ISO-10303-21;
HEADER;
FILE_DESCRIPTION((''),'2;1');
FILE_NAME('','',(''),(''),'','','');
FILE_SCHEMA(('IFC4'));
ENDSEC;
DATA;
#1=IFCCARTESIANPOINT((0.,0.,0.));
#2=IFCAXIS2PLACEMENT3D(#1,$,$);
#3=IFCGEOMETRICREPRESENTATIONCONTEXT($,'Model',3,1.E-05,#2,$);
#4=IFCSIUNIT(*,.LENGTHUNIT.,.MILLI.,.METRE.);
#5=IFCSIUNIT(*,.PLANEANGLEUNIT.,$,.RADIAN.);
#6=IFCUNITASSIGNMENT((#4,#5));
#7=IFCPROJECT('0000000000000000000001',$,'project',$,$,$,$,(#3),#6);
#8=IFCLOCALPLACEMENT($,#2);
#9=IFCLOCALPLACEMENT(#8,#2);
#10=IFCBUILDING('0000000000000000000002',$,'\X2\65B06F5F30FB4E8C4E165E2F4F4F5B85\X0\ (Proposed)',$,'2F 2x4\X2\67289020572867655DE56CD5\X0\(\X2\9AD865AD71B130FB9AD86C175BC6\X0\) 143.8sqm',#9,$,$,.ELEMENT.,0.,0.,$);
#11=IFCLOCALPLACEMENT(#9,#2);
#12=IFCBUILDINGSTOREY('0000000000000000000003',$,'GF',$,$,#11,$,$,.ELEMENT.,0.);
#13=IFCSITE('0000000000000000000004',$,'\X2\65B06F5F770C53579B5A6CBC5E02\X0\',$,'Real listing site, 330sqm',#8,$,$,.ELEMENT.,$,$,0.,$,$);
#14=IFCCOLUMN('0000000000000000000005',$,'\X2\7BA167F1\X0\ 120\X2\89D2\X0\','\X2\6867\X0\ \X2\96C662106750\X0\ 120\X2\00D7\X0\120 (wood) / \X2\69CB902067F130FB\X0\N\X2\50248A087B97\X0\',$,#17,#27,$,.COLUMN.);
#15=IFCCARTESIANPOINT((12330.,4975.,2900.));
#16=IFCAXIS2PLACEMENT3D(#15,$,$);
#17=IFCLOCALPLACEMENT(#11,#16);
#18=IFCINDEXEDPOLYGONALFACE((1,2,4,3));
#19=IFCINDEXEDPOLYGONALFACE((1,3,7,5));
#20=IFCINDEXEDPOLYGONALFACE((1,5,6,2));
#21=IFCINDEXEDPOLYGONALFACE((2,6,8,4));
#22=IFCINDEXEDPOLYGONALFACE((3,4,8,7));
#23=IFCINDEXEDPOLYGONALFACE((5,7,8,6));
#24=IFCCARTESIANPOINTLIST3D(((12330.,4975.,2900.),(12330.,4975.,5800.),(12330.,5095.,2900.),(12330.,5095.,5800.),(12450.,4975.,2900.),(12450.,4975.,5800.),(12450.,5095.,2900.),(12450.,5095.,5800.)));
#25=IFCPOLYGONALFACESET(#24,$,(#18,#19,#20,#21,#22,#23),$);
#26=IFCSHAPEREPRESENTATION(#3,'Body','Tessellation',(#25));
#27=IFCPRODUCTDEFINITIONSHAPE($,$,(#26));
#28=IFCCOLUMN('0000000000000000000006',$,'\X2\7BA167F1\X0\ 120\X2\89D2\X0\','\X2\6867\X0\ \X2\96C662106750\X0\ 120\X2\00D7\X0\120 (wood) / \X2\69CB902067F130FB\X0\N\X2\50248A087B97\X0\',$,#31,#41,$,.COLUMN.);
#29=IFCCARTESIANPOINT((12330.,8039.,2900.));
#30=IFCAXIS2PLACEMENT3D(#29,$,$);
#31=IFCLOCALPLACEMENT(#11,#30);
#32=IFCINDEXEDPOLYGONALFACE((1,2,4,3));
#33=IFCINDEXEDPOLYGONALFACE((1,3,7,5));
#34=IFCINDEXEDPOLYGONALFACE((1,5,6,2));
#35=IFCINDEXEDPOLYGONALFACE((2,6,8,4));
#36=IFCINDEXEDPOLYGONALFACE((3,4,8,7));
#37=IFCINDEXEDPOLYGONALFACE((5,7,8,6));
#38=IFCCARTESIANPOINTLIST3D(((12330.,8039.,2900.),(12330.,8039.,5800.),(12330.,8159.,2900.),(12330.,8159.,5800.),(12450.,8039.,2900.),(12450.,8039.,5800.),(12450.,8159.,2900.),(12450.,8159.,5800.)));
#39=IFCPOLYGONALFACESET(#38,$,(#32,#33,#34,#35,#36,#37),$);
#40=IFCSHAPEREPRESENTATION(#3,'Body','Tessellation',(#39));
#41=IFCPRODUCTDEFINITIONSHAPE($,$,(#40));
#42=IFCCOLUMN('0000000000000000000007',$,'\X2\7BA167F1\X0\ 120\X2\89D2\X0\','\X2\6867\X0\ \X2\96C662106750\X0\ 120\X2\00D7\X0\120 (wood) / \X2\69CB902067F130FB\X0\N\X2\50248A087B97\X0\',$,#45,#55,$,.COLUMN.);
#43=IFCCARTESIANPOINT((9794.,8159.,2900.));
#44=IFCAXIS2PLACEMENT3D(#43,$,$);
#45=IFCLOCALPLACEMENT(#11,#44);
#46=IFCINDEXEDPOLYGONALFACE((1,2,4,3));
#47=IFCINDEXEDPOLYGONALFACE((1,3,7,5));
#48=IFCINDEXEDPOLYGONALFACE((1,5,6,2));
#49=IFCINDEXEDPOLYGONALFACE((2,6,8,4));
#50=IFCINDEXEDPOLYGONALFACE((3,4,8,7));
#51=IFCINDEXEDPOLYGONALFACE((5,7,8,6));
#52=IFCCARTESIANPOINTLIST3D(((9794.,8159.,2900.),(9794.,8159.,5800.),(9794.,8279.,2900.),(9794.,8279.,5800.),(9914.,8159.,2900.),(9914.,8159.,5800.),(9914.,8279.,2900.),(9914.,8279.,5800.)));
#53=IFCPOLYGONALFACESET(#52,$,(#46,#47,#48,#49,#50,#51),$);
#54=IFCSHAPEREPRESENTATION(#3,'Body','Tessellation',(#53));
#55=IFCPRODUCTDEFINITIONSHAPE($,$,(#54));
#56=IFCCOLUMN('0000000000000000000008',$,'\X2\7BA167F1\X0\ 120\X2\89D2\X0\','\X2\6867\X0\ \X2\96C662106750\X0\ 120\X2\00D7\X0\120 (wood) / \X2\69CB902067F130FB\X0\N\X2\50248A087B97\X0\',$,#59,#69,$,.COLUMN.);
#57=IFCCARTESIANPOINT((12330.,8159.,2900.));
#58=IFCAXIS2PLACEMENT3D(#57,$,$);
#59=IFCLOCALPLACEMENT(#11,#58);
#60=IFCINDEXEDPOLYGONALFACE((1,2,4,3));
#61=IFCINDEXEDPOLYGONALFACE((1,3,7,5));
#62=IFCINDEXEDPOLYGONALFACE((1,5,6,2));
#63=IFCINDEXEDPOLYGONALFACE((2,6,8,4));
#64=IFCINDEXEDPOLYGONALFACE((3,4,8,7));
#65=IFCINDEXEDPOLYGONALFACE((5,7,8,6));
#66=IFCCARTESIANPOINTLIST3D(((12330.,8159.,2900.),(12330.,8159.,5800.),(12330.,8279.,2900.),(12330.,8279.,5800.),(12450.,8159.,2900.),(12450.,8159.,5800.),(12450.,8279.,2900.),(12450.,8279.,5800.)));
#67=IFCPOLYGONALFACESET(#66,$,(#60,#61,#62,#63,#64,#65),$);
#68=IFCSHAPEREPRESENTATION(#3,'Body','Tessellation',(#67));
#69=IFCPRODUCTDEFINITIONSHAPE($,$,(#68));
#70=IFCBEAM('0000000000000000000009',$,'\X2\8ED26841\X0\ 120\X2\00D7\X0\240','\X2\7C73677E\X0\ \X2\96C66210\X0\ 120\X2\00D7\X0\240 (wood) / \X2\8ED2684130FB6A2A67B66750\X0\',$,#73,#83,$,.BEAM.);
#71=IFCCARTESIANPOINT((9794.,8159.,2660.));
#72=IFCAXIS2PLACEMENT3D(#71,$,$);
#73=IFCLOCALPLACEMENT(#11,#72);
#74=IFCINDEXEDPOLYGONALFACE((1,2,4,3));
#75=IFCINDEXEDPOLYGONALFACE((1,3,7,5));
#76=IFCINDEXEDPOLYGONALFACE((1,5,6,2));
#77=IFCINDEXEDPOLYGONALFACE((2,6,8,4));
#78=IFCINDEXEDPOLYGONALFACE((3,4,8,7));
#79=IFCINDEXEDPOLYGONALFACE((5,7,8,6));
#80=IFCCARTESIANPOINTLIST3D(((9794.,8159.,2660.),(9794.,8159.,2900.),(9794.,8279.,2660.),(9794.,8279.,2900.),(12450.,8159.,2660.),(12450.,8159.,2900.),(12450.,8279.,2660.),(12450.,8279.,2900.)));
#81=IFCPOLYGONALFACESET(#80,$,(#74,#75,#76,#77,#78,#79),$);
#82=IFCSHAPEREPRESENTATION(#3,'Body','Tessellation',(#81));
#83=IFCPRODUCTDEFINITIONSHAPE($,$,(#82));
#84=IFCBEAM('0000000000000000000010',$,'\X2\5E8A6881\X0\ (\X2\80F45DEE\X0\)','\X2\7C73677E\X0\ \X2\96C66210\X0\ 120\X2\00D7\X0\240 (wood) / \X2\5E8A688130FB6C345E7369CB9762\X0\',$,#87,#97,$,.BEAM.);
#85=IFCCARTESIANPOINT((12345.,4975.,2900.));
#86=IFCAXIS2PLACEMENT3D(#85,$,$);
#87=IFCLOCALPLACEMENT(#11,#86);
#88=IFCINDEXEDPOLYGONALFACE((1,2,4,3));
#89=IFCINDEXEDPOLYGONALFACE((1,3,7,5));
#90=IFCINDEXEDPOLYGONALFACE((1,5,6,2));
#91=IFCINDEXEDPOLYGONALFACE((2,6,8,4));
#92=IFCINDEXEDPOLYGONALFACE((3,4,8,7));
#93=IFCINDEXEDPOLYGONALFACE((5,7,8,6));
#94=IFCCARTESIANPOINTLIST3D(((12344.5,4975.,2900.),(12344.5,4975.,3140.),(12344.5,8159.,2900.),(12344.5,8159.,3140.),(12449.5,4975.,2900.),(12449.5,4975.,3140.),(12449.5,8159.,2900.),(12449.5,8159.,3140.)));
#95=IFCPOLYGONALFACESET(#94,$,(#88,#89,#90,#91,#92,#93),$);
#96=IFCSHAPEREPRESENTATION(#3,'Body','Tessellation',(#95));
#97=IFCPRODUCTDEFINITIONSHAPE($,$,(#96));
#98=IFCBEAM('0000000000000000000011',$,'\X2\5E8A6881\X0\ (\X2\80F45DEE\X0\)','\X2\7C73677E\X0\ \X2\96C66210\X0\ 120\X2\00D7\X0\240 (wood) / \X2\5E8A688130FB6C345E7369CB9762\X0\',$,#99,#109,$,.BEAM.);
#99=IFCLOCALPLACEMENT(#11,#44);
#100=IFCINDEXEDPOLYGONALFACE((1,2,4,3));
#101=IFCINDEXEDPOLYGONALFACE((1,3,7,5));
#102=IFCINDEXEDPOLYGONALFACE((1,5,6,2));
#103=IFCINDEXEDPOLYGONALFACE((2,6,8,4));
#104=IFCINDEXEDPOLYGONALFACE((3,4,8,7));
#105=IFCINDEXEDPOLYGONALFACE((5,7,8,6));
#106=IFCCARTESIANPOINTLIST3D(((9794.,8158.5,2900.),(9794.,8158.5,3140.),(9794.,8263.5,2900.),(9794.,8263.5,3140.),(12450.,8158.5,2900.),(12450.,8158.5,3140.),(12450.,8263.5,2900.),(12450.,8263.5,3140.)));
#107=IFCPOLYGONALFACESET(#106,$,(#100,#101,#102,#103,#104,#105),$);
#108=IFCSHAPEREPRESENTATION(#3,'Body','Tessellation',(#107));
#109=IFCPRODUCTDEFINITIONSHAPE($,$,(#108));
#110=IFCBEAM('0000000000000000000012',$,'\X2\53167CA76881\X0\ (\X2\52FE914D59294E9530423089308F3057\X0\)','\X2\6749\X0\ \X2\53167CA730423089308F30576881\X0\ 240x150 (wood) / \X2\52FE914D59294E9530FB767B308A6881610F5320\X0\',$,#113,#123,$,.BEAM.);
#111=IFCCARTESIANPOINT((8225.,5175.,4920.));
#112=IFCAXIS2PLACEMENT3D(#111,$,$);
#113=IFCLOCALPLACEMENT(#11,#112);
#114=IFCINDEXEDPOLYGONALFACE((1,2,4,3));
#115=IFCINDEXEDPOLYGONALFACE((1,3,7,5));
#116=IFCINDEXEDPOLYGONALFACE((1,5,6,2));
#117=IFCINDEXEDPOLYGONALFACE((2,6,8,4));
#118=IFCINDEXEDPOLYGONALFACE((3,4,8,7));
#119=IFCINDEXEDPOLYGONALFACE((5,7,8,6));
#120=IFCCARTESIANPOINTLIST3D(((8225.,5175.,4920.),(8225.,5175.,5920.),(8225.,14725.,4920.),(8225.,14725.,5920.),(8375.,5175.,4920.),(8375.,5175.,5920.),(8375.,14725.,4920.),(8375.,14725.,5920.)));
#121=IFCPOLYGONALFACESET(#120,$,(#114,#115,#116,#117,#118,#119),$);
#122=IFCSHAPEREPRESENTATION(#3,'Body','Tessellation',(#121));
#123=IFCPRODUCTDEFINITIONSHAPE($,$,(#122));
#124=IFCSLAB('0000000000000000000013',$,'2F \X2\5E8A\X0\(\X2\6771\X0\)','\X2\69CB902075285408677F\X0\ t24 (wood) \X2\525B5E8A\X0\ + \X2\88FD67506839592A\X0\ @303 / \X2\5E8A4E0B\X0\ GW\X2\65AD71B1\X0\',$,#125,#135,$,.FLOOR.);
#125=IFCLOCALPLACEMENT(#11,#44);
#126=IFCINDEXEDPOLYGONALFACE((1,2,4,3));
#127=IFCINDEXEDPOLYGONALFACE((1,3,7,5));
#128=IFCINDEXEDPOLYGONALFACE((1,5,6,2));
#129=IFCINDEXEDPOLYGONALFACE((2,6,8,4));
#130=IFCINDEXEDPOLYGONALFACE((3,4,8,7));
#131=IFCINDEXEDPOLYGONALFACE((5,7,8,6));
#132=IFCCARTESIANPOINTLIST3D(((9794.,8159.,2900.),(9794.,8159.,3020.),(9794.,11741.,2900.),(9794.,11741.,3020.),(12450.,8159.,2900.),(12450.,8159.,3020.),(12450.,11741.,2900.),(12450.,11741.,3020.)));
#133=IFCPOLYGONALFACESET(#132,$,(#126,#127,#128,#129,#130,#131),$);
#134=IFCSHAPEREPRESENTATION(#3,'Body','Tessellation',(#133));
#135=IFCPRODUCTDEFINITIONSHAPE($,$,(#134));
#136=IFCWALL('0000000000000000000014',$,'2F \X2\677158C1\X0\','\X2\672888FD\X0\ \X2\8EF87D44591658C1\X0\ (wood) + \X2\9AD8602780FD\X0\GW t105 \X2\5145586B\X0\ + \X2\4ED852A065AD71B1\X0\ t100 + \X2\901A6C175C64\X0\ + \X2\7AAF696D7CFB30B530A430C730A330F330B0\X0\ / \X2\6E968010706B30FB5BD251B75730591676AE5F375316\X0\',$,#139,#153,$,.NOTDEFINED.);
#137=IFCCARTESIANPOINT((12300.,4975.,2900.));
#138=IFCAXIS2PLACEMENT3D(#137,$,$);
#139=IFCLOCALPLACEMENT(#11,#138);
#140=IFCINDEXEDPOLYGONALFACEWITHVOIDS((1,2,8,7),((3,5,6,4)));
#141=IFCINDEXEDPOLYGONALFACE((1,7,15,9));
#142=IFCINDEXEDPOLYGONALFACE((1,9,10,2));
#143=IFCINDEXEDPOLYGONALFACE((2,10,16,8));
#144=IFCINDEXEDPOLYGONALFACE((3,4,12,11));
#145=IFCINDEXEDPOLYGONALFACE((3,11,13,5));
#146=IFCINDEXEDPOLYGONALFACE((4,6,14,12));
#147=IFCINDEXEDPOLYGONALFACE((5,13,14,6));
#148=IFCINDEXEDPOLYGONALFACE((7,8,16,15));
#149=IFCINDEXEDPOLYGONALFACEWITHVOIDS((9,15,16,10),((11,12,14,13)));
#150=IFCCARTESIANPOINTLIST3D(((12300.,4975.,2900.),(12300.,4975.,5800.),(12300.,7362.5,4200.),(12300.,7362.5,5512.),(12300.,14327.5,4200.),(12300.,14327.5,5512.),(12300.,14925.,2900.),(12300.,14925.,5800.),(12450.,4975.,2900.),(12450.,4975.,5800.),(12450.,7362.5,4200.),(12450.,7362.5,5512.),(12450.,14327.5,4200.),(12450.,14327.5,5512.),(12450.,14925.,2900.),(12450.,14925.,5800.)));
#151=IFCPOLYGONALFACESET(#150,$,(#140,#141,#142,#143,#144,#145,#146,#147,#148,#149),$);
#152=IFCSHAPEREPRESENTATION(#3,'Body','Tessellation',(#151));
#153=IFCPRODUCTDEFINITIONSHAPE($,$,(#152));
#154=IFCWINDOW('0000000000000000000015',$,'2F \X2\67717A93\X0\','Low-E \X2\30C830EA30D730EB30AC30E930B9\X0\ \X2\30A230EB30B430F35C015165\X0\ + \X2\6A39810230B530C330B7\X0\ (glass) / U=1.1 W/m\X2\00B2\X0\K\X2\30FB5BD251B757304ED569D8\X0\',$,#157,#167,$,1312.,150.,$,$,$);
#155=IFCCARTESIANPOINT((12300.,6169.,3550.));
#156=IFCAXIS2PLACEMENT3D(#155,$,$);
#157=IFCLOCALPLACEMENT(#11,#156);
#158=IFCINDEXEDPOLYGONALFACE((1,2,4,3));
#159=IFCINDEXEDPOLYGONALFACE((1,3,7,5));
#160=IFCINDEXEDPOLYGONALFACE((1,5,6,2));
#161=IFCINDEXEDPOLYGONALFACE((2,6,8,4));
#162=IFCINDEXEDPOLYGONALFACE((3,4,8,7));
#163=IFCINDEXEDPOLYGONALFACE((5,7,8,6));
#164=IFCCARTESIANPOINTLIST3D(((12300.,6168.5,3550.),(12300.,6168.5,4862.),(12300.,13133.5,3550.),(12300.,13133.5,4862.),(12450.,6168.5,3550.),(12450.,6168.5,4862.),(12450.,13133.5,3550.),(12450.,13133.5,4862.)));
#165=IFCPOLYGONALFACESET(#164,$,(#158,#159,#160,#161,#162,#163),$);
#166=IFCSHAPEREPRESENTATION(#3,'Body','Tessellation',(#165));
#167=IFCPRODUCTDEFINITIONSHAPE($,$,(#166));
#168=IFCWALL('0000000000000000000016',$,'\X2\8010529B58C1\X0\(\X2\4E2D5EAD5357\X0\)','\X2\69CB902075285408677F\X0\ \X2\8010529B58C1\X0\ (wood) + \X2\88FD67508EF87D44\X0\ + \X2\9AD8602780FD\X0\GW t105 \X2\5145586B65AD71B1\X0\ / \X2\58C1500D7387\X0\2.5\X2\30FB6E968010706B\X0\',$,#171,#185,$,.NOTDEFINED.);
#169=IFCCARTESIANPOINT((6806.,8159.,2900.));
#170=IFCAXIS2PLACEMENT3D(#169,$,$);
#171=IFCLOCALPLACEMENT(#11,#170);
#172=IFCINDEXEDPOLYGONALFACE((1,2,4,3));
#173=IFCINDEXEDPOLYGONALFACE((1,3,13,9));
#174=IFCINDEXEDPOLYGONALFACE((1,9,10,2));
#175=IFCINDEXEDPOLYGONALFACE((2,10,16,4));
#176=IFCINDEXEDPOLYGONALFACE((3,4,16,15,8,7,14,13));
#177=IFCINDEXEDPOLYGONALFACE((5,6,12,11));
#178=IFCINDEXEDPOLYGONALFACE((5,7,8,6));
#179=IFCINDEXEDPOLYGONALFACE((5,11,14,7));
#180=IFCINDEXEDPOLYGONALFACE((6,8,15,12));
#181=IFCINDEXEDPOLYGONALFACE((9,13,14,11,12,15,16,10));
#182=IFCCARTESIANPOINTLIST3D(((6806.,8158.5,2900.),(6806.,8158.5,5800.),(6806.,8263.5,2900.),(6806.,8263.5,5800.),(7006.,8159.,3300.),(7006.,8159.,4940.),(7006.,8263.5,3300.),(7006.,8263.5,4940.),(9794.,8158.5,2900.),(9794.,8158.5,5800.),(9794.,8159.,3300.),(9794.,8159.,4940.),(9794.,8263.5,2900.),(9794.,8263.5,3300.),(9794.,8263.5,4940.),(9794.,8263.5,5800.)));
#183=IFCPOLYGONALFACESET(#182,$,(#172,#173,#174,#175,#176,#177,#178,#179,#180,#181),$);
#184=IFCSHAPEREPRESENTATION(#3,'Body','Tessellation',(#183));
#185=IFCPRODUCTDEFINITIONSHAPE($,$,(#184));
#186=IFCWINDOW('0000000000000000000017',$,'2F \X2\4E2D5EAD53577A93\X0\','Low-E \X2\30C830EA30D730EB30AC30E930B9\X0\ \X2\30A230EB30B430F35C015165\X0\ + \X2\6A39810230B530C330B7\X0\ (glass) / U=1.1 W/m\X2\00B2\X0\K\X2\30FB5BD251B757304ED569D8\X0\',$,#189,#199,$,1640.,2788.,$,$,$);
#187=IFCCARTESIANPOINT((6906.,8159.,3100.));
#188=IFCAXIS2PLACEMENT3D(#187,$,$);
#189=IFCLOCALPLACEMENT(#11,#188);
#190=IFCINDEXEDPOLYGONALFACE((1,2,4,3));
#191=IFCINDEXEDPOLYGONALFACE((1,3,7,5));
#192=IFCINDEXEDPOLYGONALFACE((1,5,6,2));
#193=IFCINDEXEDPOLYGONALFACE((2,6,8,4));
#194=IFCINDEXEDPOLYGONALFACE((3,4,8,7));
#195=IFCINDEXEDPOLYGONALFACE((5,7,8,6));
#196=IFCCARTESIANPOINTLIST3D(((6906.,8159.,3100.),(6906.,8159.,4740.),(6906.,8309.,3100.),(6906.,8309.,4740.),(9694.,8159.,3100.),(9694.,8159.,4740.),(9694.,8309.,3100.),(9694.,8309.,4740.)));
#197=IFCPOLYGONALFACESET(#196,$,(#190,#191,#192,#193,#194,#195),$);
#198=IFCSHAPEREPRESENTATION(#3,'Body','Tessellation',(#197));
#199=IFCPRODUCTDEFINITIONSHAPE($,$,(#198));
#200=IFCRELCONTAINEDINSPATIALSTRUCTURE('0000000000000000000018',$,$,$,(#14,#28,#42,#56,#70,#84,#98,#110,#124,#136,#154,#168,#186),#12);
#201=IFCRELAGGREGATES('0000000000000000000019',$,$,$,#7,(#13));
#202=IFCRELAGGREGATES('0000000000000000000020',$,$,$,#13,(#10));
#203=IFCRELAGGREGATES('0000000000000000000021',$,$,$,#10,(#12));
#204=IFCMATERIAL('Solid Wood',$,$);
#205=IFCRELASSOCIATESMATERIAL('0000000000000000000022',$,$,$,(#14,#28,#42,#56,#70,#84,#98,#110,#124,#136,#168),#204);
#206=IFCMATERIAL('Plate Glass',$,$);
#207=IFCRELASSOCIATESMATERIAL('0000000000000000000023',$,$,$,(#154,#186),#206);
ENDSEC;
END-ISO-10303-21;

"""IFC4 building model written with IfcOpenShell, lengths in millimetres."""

from ifc_helpers import new_model, si_unit, frame, frame_2d, origin, place, context, project, spatial, rectangle, extrude, material, element, fill, save


model = new_model("IFC4")

# Units and contexts
model_context = context("Model", 3, precision=1e-05, world=origin())
ifc_project = project(units=[si_unit("LENGTHUNIT", "METRE", prefix="MILLI"), si_unit("PLANEANGLEUNIT", "RADIAN")], contexts=[model_context])

# Site, building, storey
site_placement = place(None, origin())
site = spatial("IfcSite", under=ifc_project, at=site_placement, Name="新潟県南魚沼市", ObjectType="Real listing site, 330sqm", CompositionType="ELEMENT", RefElevation=0.0)
building_placement = place(site_placement, origin())
building = spatial("IfcBuilding", under=site, at=building_placement, Name="新潟・二世帯住宅 (Proposed)", ObjectType="2F 2x4木造在来工法(高断熱・高気密) 143.8sqm", CompositionType="ELEMENT", ElevationOfRefHeight=0.0, ElevationOfTerrain=0.0)
storey_placement = place(building_placement, origin())
storey = spatial("IfcBuildingStorey", under=building, at=storey_placement, Name="GF", CompositionType="ELEMENT", Elevation=0.0)

# Columns
ifc_material_1 = material(Name="Solid Wood")
column_1_placement = place(storey_placement, frame((12330.0, 4975.0, 2900.0)))
element("IfcColumn", 1, at=column_1_placement, inside=storey, material=ifc_material_1, Name="管柱 120角", Description="桧 集成材 120×120 (wood) / 構造柱・N値計算", PredefinedType="COLUMN", context=model_context, shape_type="SweptSolid", body=[
    extrude(rectangle(XDim=120.0, YDim=120.0, at=frame_2d((60.0, 60.0))), frame((12330.0, 4975.0, 2900.0)), (0.0, 0.0, 1.0), 2900.0),
])
column_2_placement = place(storey_placement, frame((12330.0, 8039.0, 2900.0)))
element("IfcColumn", 2, at=column_2_placement, inside=storey, material=ifc_material_1, Name="管柱 120角", Description="桧 集成材 120×120 (wood) / 構造柱・N値計算", PredefinedType="COLUMN", context=model_context, shape_type="SweptSolid", body=[
    extrude(rectangle(XDim=120.0, YDim=120.0, at=frame_2d((60.0, 60.0))), frame((12330.0, 8039.0, 2900.0)), (0.0, 0.0, 1.0), 2900.0),
])
column_3_placement = place(storey_placement, frame((9794.0, 8159.0, 2900.0)))
element("IfcColumn", 3, at=column_3_placement, inside=storey, material=ifc_material_1, Name="管柱 120角", Description="桧 集成材 120×120 (wood) / 構造柱・N値計算", PredefinedType="COLUMN", context=model_context, shape_type="SweptSolid", body=[
    extrude(rectangle(XDim=120.0, YDim=120.0, at=frame_2d((60.0, 60.0))), frame((9794.0, 8159.0, 2900.0)), (0.0, 0.0, 1.0), 2900.0),
])
column_4_placement = place(storey_placement, frame((12330.0, 8159.0, 2900.0)))
element("IfcColumn", 4, at=column_4_placement, inside=storey, material=ifc_material_1, Name="管柱 120角", Description="桧 集成材 120×120 (wood) / 構造柱・N値計算", PredefinedType="COLUMN", context=model_context, shape_type="SweptSolid", body=[
    extrude(rectangle(XDim=120.0, YDim=120.0, at=frame_2d((60.0, 60.0))), frame((12330.0, 8159.0, 2900.0)), (0.0, 0.0, 1.0), 2900.0),
])

# Beams
beam_1_placement = place(storey_placement, frame((9794.0, 8159.0, 2660.0)))
element("IfcBeam", 5, at=beam_1_placement, inside=storey, material=ifc_material_1, Name="軒桁 120×240", Description="米松 集成 120×240 (wood) / 軒桁・横架材", PredefinedType="BEAM", context=model_context, shape_type="SweptSolid", body=[
    extrude(rectangle(XDim=2656.0, YDim=120.0, at=frame_2d((1328.0, 60.0))), frame((9794.0, 8159.0, 2660.0)), (0.0, 0.0, 1.0), 240.0),
])
beam_2_placement = place(storey_placement, frame((12345.0, 4975.0, 2900.0)))
element("IfcBeam", 6, at=beam_2_placement, inside=storey, material=ifc_material_1, Name="床梁 (胴差)", Description="米松 集成 120×240 (wood) / 床梁・水平構面", PredefinedType="BEAM", context=model_context, shape_type="SweptSolid", body=[
    extrude(rectangle(XDim=105.0, YDim=3184.0, at=frame_2d((52.0, 1592.0))), frame((12345.0, 4975.0, 2900.0)), (0.0, 0.0, 1.0), 240.0),
])
beam_3_placement = place(storey_placement, frame((9794.0, 8159.0, 2900.0)))
element("IfcBeam", 7, at=beam_3_placement, inside=storey, material=ifc_material_1, Name="床梁 (胴差)", Description="米松 集成 120×240 (wood) / 床梁・水平構面", PredefinedType="BEAM", context=model_context, shape_type="SweptSolid", body=[
    extrude(rectangle(XDim=2656.0, YDim=105.0, at=frame_2d((1328.0, 52.0))), frame((9794.0, 8159.0, 2900.0)), (0.0, 0.0, 1.0), 240.0),
])
beam_4_placement = place(storey_placement, frame((8225.0, 5175.0, 4920.0)))
element("IfcBeam", 8, at=beam_4_placement, inside=storey, material=ifc_material_1, Name="化粧梁 (勾配天井あらわし)", Description="杉 化粧あらわし梁 240x150 (wood) / 勾配天井・登り梁意匠", PredefinedType="BEAM", context=model_context, shape_type="SweptSolid", body=[
    extrude(rectangle(XDim=150.0, YDim=9550.0, at=frame_2d((75.0, 4775.0))), frame((8225.0, 5175.0, 4920.0)), (0.0, 0.0, 1.0), 1000.0),
])

# Slab
slab_placement = place(storey_placement, frame((9794.0, 8159.0, 2900.0)))
element("IfcSlab", 9, at=slab_placement, inside=storey, material=ifc_material_1, Name="2F 床(東)", Description="構造用合板 t24 (wood) 剛床 + 製材根太 @303 / 床下 GW断熱", PredefinedType="FLOOR", context=model_context, shape_type="SweptSolid", body=[
    extrude(rectangle(XDim=2656.0, YDim=3582.0, at=frame_2d((1328.0, 1791.0))), frame((9794.0, 8159.0, 2900.0)), (0.0, 0.0, 1.0), 120.0),
])

# Walls, openings, windows
wall_1_placement = place(storey_placement, frame((12300.0, 4975.0, 2900.0)))
wall_1 = element("IfcWall", 10, at=wall_1_placement, inside=storey, material=ifc_material_1, Name="2F 東壁", Description="木製 軸組外壁 (wood) + 高性能GW t105 充填 + 付加断熱 t100 + 通気層 + 窯業系サイディング / 準耐火・寒冷地外皮強化", PredefinedType="NOTDEFINED", context=model_context, shape_type="SweptSolid", body=[
    extrude(rectangle(XDim=150.0, YDim=9950.0, at=frame_2d((75.0, 4975.0))), frame((12300.0, 4975.0, 2900.0)), (0.0, 0.0, 1.0), 2900.0),
])
opening_1_placement = place(storey_placement, frame((12300.0, 6169.0, 3550.0)))
opening_1 = element("IfcOpeningElement", 11, at=opening_1_placement, cuts=wall_1, PredefinedType="NOTDEFINED", context=model_context, shape_type="SweptSolid", body=[
    extrude(rectangle(XDim=150.0, YDim=6965.0, at=frame_2d((75.0, 3482.0))), frame((12300.0, 6169.0, 3550.0)), (0.0, 0.0, 1.0), 1312.0),
])
ifc_material_2 = material(Name="Plate Glass")
window_1_placement = place(storey_placement, frame((12300.0, 6169.0, 3550.0)))
window_1 = element("IfcWindow", 12, at=window_1_placement, inside=storey, material=ifc_material_2, Name="2F 東窓", Description="Low-E トリプルガラス アルゴン封入 + 樹脂サッシ (glass) / U=1.1 W/m²K・寒冷地仕様", OverallHeight=1312.0, OverallWidth=150.0, context=model_context, shape_type="SweptSolid", body=[
    extrude(rectangle(XDim=150.0, YDim=6965.0, at=frame_2d((75.0, 3482.0))), frame((12300.0, 6169.0, 3550.0)), (0.0, 0.0, 1.0), 1312.0),
])
fill(opening_1, window_1)
wall_2_placement = place(storey_placement, frame((6806.0, 8159.0, 2900.0)))
wall_2 = element("IfcWall", 13, at=wall_2_placement, inside=storey, material=ifc_material_1, Name="耐力壁(中庭南)", Description="構造用合板 耐力壁 (wood) + 製材軸組 + 高性能GW t105 充填断熱 / 壁倍率2.5・準耐火", PredefinedType="NOTDEFINED", context=model_context, shape_type="SweptSolid", body=[
    extrude(rectangle(XDim=2988.0, YDim=105.0, at=frame_2d((1494.0, 52.0))), frame((6806.0, 8159.0, 2900.0)), (0.0, 0.0, 1.0), 2900.0),
])
opening_2_placement = place(storey_placement, frame((6906.0, 8159.0, 3100.0)))
opening_2 = element("IfcOpeningElement", 14, at=opening_2_placement, cuts=wall_2, PredefinedType="NOTDEFINED", context=model_context, shape_type="SweptSolid", body=[
    extrude(rectangle(XDim=2788.0, YDim=150.0, at=frame_2d((1394.0, 75.0))), frame((6906.0, 8159.0, 3100.0)), (0.0, 0.0, 1.0), 1640.0),
])
window_2_placement = place(storey_placement, frame((6906.0, 8159.0, 3100.0)))
window_2 = element("IfcWindow", 15, at=window_2_placement, inside=storey, material=ifc_material_2, Name="2F 中庭南窓", Description="Low-E トリプルガラス アルゴン封入 + 樹脂サッシ (glass) / U=1.1 W/m²K・寒冷地仕様", OverallHeight=1640.0, OverallWidth=2788.0, context=model_context, shape_type="SweptSolid", body=[
    extrude(rectangle(XDim=2788.0, YDim=150.0, at=frame_2d((1394.0, 75.0))), frame((6906.0, 8159.0, 3100.0)), (0.0, 0.0, 1.0), 1640.0),
])
fill(opening_2, window_2)

save(model, "model.ifc")
